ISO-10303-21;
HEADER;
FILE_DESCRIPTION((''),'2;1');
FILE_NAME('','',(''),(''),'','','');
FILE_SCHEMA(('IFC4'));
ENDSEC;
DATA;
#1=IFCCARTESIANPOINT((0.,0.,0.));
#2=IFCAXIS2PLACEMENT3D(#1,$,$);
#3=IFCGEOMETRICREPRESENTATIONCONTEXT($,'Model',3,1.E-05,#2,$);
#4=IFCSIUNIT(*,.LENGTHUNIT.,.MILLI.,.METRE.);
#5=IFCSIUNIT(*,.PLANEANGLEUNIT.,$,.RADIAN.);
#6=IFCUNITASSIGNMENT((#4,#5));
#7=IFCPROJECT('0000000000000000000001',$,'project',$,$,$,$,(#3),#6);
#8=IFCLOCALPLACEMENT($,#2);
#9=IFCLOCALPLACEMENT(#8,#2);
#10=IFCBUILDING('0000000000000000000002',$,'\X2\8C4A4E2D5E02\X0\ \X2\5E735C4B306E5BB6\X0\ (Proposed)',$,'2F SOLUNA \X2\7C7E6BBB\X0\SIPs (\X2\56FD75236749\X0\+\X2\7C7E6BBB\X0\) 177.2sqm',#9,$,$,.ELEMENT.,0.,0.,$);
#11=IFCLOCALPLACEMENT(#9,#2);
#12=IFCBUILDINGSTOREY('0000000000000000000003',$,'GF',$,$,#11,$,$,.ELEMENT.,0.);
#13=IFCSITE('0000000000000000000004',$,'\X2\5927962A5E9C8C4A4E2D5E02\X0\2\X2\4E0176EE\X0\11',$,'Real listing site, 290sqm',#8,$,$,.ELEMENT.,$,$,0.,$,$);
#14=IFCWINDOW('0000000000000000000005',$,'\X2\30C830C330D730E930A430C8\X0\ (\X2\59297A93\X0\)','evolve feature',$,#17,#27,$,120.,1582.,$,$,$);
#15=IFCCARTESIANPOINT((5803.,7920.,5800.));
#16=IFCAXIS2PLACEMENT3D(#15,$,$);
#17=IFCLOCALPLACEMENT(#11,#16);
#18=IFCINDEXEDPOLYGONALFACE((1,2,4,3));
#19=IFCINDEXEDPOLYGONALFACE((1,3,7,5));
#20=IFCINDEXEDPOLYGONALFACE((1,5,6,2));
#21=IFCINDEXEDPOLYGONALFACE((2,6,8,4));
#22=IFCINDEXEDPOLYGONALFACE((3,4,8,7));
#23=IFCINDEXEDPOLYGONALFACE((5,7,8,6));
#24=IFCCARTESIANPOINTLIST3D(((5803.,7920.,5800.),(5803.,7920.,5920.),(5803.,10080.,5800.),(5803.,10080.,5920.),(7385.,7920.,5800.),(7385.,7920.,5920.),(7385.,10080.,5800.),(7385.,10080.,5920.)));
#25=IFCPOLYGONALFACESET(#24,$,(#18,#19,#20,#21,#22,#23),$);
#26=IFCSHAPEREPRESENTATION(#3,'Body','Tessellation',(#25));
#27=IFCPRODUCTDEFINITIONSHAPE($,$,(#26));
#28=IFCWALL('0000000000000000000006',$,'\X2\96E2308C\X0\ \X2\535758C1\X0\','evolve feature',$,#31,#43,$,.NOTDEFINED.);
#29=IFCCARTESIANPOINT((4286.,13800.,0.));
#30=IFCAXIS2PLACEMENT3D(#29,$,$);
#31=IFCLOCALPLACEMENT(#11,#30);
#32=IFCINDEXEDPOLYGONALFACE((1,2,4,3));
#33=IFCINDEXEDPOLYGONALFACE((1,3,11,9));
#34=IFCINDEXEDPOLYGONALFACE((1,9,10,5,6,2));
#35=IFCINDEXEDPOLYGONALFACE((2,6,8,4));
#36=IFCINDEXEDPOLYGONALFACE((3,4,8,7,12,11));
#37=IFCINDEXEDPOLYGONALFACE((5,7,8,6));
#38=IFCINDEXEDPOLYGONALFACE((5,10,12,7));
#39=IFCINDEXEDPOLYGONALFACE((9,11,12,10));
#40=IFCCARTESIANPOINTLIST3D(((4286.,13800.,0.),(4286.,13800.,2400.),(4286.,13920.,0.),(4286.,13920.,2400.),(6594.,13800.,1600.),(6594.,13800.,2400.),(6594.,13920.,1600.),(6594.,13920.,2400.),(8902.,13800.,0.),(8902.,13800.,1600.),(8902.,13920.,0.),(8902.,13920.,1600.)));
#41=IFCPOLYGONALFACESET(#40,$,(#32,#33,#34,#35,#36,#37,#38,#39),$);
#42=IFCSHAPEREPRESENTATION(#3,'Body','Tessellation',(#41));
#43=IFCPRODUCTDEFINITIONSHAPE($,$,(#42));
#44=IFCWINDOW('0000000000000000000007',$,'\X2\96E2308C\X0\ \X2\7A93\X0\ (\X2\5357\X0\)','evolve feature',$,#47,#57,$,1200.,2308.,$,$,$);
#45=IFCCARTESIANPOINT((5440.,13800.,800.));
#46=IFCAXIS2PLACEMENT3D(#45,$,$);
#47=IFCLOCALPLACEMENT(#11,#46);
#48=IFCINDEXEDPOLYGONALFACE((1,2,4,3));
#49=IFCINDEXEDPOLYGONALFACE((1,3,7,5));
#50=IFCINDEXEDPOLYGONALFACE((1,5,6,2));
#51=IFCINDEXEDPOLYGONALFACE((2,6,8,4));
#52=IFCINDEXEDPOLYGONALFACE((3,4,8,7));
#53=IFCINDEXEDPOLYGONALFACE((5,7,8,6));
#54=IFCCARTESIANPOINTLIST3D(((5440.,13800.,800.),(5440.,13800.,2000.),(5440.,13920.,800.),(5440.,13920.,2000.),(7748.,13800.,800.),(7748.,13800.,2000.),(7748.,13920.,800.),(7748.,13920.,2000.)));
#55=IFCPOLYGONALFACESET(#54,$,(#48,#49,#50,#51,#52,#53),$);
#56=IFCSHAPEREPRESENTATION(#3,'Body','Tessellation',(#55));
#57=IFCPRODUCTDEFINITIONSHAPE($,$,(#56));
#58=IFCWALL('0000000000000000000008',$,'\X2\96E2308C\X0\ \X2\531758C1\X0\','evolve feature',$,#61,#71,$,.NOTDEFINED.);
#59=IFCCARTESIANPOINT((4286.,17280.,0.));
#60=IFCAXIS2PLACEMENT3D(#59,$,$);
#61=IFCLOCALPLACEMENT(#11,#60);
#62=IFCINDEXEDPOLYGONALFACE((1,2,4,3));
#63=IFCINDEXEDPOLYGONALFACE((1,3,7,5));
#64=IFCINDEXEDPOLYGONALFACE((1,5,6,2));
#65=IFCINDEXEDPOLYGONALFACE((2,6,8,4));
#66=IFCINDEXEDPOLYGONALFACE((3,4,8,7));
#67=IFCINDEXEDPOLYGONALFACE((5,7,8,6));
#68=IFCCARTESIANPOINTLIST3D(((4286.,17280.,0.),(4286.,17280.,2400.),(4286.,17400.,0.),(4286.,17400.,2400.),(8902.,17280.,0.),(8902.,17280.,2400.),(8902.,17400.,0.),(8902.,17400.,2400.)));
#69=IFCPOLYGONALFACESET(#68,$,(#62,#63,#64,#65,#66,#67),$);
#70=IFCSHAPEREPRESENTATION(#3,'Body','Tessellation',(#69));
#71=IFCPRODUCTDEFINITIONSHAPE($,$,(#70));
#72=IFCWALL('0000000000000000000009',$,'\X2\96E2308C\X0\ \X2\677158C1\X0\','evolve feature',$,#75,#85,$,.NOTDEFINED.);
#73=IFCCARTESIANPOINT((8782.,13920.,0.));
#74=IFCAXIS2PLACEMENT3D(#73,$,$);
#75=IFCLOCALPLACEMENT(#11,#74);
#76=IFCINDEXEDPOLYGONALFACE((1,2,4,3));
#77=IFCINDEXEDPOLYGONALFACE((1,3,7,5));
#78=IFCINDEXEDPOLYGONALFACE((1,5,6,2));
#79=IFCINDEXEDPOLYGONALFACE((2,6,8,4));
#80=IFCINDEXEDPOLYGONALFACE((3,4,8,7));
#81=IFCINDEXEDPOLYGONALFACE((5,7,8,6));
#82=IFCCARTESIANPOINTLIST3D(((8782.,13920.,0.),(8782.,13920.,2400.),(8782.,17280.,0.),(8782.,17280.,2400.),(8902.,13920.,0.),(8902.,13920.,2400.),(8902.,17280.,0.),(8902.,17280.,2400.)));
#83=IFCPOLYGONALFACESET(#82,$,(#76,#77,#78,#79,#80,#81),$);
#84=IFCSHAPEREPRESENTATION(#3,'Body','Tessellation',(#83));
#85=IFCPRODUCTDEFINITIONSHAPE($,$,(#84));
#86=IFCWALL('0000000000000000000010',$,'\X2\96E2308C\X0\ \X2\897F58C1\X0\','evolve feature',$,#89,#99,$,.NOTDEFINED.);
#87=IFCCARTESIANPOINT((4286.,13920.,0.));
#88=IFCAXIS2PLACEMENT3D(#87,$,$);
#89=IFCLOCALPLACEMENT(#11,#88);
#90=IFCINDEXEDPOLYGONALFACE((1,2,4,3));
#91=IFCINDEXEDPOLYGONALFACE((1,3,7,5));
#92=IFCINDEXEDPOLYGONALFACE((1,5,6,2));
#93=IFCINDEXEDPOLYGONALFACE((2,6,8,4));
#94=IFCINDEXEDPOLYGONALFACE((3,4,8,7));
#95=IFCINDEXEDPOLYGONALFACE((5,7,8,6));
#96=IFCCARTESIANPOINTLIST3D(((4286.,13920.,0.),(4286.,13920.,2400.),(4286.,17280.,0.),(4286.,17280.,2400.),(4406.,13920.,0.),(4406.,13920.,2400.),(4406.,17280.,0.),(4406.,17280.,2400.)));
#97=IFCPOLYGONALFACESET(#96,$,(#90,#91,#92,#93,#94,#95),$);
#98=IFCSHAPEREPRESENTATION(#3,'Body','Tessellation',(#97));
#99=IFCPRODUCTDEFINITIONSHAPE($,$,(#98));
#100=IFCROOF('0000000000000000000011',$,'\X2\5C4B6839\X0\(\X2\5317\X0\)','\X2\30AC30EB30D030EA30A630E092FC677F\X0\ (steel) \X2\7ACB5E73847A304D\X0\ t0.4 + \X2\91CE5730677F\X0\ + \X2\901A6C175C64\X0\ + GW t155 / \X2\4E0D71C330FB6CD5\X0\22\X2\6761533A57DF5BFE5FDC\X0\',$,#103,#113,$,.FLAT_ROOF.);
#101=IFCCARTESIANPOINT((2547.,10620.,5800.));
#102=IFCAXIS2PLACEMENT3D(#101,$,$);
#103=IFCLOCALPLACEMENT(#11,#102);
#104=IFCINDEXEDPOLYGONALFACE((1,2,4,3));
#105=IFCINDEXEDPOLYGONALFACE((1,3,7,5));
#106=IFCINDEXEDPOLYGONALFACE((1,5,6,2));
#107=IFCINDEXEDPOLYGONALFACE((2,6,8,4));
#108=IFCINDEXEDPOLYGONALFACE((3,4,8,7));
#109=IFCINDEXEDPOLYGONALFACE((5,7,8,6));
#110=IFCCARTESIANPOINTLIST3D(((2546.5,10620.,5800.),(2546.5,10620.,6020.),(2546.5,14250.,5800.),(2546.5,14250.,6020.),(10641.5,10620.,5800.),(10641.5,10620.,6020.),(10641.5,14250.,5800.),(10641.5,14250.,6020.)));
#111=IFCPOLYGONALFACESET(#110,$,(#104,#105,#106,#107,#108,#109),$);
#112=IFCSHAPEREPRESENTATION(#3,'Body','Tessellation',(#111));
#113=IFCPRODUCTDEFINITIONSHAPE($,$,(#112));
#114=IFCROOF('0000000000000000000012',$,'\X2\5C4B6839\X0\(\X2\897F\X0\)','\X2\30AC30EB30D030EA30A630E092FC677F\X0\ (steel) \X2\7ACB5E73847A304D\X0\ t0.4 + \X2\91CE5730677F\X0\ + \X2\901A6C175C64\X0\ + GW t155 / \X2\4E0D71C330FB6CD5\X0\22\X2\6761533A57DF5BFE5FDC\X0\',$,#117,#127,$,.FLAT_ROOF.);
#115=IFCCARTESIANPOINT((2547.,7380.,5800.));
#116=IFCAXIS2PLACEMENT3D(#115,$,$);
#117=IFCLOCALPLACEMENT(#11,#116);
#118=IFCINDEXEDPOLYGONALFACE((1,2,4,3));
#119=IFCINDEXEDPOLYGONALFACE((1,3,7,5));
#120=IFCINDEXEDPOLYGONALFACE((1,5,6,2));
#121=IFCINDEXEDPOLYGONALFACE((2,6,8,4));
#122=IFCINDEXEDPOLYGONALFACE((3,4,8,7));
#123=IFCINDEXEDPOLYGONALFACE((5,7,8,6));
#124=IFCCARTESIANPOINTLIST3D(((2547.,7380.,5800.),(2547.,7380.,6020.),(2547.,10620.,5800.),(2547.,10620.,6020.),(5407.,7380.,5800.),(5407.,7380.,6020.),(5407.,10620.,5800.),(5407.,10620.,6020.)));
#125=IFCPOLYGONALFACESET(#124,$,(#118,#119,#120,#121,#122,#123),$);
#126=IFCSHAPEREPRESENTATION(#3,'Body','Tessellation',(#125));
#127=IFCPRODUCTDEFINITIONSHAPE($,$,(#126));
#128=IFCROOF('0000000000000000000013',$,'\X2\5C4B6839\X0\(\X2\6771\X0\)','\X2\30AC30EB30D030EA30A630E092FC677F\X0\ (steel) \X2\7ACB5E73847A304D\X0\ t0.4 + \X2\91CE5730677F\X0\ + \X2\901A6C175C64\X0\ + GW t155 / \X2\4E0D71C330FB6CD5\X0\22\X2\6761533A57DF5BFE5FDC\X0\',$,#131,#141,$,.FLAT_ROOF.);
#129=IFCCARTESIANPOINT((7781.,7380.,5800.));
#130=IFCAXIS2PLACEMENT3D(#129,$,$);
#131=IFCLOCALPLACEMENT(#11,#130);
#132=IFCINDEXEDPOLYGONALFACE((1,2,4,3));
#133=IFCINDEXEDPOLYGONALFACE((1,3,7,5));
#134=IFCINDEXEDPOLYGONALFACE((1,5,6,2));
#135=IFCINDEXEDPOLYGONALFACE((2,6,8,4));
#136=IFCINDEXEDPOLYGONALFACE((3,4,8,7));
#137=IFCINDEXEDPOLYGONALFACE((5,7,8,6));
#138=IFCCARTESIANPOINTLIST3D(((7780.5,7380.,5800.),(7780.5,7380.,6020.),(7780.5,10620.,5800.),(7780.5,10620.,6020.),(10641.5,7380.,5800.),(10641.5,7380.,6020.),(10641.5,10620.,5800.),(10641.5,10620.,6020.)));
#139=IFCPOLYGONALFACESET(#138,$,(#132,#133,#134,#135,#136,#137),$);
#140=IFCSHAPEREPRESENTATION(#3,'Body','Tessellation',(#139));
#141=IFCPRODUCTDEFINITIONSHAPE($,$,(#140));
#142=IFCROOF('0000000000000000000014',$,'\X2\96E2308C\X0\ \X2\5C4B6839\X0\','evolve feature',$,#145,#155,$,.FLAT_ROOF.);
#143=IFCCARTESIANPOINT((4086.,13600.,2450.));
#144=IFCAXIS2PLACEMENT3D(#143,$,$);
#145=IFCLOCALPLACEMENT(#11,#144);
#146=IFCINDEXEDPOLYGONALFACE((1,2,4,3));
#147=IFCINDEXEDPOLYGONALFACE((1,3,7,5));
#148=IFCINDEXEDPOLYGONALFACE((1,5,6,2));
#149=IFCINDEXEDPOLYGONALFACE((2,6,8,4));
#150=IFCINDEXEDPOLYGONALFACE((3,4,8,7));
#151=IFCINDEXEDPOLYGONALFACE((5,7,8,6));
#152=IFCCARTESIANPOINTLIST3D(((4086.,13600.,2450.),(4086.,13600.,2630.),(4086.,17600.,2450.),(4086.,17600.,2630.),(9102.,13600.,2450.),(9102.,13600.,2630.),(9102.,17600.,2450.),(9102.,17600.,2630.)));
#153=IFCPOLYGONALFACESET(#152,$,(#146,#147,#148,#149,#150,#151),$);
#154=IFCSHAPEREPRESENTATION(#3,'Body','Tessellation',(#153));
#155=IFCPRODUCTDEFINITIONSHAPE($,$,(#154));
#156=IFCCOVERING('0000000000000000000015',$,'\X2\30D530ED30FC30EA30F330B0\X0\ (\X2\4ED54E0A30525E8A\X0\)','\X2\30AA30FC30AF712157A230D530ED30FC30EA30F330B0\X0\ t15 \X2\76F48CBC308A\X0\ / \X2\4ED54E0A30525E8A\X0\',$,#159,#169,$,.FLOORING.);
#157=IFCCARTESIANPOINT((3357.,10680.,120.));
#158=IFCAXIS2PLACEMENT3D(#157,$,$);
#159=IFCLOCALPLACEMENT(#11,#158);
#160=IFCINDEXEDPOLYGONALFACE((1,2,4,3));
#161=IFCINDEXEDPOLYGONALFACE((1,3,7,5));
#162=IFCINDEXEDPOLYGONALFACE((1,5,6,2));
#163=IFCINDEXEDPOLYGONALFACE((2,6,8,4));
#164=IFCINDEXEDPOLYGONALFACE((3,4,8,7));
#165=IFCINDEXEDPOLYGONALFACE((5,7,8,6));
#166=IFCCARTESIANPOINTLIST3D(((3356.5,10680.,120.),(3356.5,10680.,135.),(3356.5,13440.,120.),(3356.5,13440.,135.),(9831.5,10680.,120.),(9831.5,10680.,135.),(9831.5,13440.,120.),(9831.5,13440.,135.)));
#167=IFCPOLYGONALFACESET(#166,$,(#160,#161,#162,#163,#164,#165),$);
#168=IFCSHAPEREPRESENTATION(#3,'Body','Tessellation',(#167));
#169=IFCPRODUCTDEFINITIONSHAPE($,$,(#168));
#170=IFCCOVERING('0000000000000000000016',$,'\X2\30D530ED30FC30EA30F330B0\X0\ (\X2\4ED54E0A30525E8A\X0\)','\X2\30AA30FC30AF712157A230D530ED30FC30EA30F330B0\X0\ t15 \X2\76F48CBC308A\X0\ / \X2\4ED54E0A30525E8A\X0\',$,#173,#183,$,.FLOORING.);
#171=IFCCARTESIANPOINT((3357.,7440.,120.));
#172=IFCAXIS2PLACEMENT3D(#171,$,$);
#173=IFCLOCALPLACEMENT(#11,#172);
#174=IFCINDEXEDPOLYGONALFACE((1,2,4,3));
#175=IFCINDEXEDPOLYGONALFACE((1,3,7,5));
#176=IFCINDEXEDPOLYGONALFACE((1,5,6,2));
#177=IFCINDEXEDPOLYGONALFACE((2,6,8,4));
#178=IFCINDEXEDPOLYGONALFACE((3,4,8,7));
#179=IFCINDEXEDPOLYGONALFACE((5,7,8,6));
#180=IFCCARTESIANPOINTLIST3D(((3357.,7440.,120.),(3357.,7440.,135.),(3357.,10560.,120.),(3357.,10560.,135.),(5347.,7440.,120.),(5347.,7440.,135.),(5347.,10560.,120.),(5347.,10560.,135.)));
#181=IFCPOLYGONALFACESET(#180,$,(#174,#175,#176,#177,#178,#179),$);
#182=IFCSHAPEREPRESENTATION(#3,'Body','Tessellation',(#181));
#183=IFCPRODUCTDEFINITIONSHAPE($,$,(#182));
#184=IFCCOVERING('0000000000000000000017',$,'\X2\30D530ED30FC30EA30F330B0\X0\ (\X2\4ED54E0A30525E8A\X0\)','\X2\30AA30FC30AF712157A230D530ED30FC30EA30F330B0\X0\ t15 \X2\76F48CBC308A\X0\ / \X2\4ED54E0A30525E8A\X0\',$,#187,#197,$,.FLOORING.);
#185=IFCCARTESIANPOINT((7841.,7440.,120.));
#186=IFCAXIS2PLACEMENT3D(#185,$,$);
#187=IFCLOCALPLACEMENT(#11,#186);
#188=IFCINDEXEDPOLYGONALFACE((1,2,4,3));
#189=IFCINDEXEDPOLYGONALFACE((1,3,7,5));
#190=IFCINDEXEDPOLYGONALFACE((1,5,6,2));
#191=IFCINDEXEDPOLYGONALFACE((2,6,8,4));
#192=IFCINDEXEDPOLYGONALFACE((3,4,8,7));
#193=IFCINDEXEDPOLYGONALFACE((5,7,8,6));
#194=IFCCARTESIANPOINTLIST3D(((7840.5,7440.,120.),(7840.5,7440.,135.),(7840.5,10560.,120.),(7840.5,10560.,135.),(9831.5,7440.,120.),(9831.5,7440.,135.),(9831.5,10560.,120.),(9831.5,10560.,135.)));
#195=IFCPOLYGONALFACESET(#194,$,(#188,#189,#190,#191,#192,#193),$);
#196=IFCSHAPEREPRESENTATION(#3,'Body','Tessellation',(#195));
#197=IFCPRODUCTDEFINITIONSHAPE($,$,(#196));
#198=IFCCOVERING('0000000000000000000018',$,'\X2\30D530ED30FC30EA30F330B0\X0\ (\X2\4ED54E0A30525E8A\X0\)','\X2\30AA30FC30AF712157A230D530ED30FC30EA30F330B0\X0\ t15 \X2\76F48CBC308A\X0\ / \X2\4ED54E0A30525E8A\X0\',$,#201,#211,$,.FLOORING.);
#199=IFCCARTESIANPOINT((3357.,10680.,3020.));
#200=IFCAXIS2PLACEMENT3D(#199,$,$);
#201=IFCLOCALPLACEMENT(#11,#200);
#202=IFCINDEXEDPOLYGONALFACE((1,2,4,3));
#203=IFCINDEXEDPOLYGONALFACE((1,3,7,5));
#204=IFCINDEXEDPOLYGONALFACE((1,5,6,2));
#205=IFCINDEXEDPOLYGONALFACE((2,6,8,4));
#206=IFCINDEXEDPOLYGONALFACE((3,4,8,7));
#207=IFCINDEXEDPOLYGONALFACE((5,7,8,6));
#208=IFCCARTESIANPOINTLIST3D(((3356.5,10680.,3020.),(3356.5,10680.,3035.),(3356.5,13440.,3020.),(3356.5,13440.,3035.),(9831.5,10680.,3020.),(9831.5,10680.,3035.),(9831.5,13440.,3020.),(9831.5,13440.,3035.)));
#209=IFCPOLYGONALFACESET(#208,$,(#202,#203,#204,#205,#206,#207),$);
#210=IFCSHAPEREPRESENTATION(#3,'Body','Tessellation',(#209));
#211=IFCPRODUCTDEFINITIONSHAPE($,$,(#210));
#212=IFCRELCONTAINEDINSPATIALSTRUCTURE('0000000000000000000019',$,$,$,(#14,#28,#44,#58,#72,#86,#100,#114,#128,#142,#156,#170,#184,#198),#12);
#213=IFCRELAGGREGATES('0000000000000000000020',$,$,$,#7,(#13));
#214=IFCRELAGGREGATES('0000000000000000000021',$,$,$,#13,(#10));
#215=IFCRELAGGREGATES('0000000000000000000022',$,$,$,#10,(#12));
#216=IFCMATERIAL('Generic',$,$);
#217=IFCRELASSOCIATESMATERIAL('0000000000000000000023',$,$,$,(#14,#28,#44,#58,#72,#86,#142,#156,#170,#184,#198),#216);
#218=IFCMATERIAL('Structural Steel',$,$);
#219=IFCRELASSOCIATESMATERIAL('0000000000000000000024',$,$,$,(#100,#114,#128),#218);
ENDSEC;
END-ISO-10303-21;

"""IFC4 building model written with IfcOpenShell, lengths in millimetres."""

from ifc_helpers import new_model, si_unit, frame, frame_2d, origin, place, context, project, spatial, rectangle, extrude, material, element, fill, save


model = new_model("IFC4")

# Units and contexts
model_context = context("Model", 3, precision=1e-05, world=origin())
ifc_project = project(units=[si_unit("LENGTHUNIT", "METRE", prefix="MILLI"), si_unit("PLANEANGLEUNIT", "RADIAN")], contexts=[model_context])

# Site, building, storey
site_placement = place(None, origin())
site = spatial("IfcSite", under=ifc_project, at=site_placement, Name="大阪府豊中市2丁目11", ObjectType="Real listing site, 290sqm", CompositionType="ELEMENT", RefElevation=0.0)
building_placement = place(site_placement, origin())
building = spatial("IfcBuilding", under=site, at=building_placement, Name="豊中市 平屋の家 (Proposed)", ObjectType="2F SOLUNA 籾殻SIPs (国産杉+籾殻) 177.2sqm", CompositionType="ELEMENT", ElevationOfRefHeight=0.0, ElevationOfTerrain=0.0)
storey_placement = place(building_placement, origin())
storey = spatial("IfcBuildingStorey", under=building, at=storey_placement, Name="GF", CompositionType="ELEMENT", Elevation=0.0)

# Shared definitions
ifc_material_1 = material(Name="Generic")

# Window
window_1_placement = place(storey_placement, frame((5803.0, 7920.0, 5800.0)))
element("IfcWindow", 1, at=window_1_placement, inside=storey, material=ifc_material_1, Name="トップライト (天窓)", Description="evolve feature", OverallHeight=120.0, OverallWidth=1582.0, context=model_context, shape_type="SweptSolid", body=[
    extrude(rectangle(XDim=1582.0, YDim=2160.0, at=frame_2d((791.0, 1080.0))), frame((5803.0, 7920.0, 5800.0)), (0.0, 0.0, 1.0), 120.0),
])

# Wall, opening, window
wall_1_placement = place(storey_placement, frame((4286.0, 13800.0, 0.0)))
wall_1 = element("IfcWall", 2, at=wall_1_placement, inside=storey, material=ifc_material_1, Name="離れ 南壁", Description="evolve feature", PredefinedType="NOTDEFINED", context=model_context, shape_type="SweptSolid", body=[
    extrude(rectangle(XDim=4616.0, YDim=120.0, at=frame_2d((2308.0, 60.0))), frame((4286.0, 13800.0, 0.0)), (0.0, 0.0, 1.0), 2400.0),
])
opening_1_placement = place(storey_placement, frame((5440.0, 13800.0, 800.0)))
opening_1 = element("IfcOpeningElement", 3, at=opening_1_placement, cuts=wall_1, PredefinedType="NOTDEFINED", context=model_context, shape_type="SweptSolid", body=[
    extrude(rectangle(XDim=2308.0, YDim=120.0, at=frame_2d((1154.0, 60.0))), frame((5440.0, 13800.0, 800.0)), (0.0, 0.0, 1.0), 1200.0),
])
window_2_placement = place(storey_placement, frame((5440.0, 13800.0, 800.0)))
window_2 = element("IfcWindow", 4, at=window_2_placement, inside=storey, material=ifc_material_1, Name="離れ 窓 (南)", Description="evolve feature", OverallHeight=1200.0, OverallWidth=2308.0, context=model_context, shape_type="SweptSolid", body=[
    extrude(rectangle(XDim=2308.0, YDim=120.0, at=frame_2d((1154.0, 60.0))), frame((5440.0, 13800.0, 800.0)), (0.0, 0.0, 1.0), 1200.0),
])
fill(opening_1, window_2)

# Walls
wall_2_placement = place(storey_placement, frame((4286.0, 17280.0, 0.0)))
element("IfcWall", 5, at=wall_2_placement, inside=storey, material=ifc_material_1, Name="離れ 北壁", Description="evolve feature", PredefinedType="NOTDEFINED", context=model_context, shape_type="SweptSolid", body=[
    extrude(rectangle(XDim=4616.0, YDim=120.0, at=frame_2d((2308.0, 60.0))), frame((4286.0, 17280.0, 0.0)), (0.0, 0.0, 1.0), 2400.0),
])
wall_3_placement = place(storey_placement, frame((8782.0, 13920.0, 0.0)))
element("IfcWall", 6, at=wall_3_placement, inside=storey, material=ifc_material_1, Name="離れ 東壁", Description="evolve feature", PredefinedType="NOTDEFINED", context=model_context, shape_type="SweptSolid", body=[
    extrude(rectangle(XDim=120.0, YDim=3360.0, at=frame_2d((60.0, 1680.0))), frame((8782.0, 13920.0, 0.0)), (0.0, 0.0, 1.0), 2400.0),
])
wall_4_placement = place(storey_placement, frame((4286.0, 13920.0, 0.0)))
element("IfcWall", 7, at=wall_4_placement, inside=storey, material=ifc_material_1, Name="離れ 西壁", Description="evolve feature", PredefinedType="NOTDEFINED", context=model_context, shape_type="SweptSolid", body=[
    extrude(rectangle(XDim=120.0, YDim=3360.0, at=frame_2d((60.0, 1680.0))), frame((4286.0, 13920.0, 0.0)), (0.0, 0.0, 1.0), 2400.0),
])

# Roofs
ifc_material_2 = material(Name="Structural Steel")
for number, where, name in (
    (8, (2547.0, 10620.0, 5800.0), "屋根(北)"),
):
    element("IfcRoof", number, at=place(storey_placement, frame(where)), inside=storey, material=ifc_material_2, Name=name, Description="ガルバリウム鋼板 (steel) 立平葺き t0.4 + 野地板 + 通気層 + GW t155 / 不燃・法22条区域対応", PredefinedType="FLAT_ROOF", context=model_context, shape_type="SweptSolid", body=[
        extrude(rectangle(XDim=8095.0, YDim=3630.0, at=frame_2d((4047.0, 1815.0))), frame((2547.0, 10620.0, 5800.0)), (0.0, 0.0, 1.0), 220.0),
    ])
roof_1_placement = place(storey_placement, frame((2547.0, 7380.0, 5800.0)))
element("IfcRoof", 9, at=roof_1_placement, inside=storey, material=ifc_material_2, Name="屋根(西)", Description="ガルバリウム鋼板 (steel) 立平葺き t0.4 + 野地板 + 通気層 + GW t155 / 不燃・法22条区域対応", PredefinedType="FLAT_ROOF", context=model_context, shape_type="SweptSolid", body=[
    extrude(rectangle(XDim=2860.0, YDim=3240.0, at=frame_2d((1430.0, 1620.0))), frame((2547.0, 7380.0, 5800.0)), (0.0, 0.0, 1.0), 220.0),
])
roof_2_placement = place(storey_placement, frame((7781.0, 7380.0, 5800.0)))
element("IfcRoof", 10, at=roof_2_placement, inside=storey, material=ifc_material_2, Name="屋根(東)", Description="ガルバリウム鋼板 (steel) 立平葺き t0.4 + 野地板 + 通気層 + GW t155 / 不燃・法22条区域対応", PredefinedType="FLAT_ROOF", context=model_context, shape_type="SweptSolid", body=[
    extrude(rectangle(XDim=2861.0, YDim=3240.0, at=frame_2d((1430.0, 1620.0))), frame((7781.0, 7380.0, 5800.0)), (0.0, 0.0, 1.0), 220.0),
])
roof_3_placement = place(storey_placement, frame((4086.0, 13600.0, 2450.0)))
element("IfcRoof", 11, at=roof_3_placement, inside=storey, material=ifc_material_1, Name="離れ 屋根", Description="evolve feature", PredefinedType="FLAT_ROOF", context=model_context, shape_type="SweptSolid", body=[
    extrude(rectangle(XDim=5016.0, YDim=4000.0, at=frame_2d((2508.0, 2000.0))), frame((4086.0, 13600.0, 2450.0)), (0.0, 0.0, 1.0), 180.0),
])

# Coverings
covering_1_placement = place(storey_placement, frame((3357.0, 10680.0, 120.0)))
element("IfcCovering", 12, at=covering_1_placement, inside=storey, material=ifc_material_1, Name="フローリング (仕上げ床)", Description="オーク無垢フローリング t15 直貼り / 仕上げ床", PredefinedType="FLOORING", context=model_context, shape_type="SweptSolid", body=[
    extrude(rectangle(XDim=6475.0, YDim=2760.0, at=frame_2d((3237.0, 1380.0))), frame((3357.0, 10680.0, 120.0)), (0.0, 0.0, 1.0), 15.0),
])
covering_2_placement = place(storey_placement, frame((3357.0, 7440.0, 120.0)))
element("IfcCovering", 13, at=covering_2_placement, inside=storey, material=ifc_material_1, Name="フローリング (仕上げ床)", Description="オーク無垢フローリング t15 直貼り / 仕上げ床", PredefinedType="FLOORING", context=model_context, shape_type="SweptSolid", body=[
    extrude(rectangle(XDim=1990.0, YDim=3120.0, at=frame_2d((995.0, 1560.0))), frame((3357.0, 7440.0, 120.0)), (0.0, 0.0, 1.0), 15.0),
])
covering_3_placement = place(storey_placement, frame((7841.0, 7440.0, 120.0)))
element("IfcCovering", 14, at=covering_3_placement, inside=storey, material=ifc_material_1, Name="フローリング (仕上げ床)", Description="オーク無垢フローリング t15 直貼り / 仕上げ床", PredefinedType="FLOORING", context=model_context, shape_type="SweptSolid", body=[
    extrude(rectangle(XDim=1991.0, YDim=3120.0, at=frame_2d((995.0, 1560.0))), frame((7841.0, 7440.0, 120.0)), (0.0, 0.0, 1.0), 15.0),
])
covering_4_placement = place(storey_placement, frame((3357.0, 10680.0, 3020.0)))
element("IfcCovering", 15, at=covering_4_placement, inside=storey, material=ifc_material_1, Name="フローリング (仕上げ床)", Description="オーク無垢フローリング t15 直貼り / 仕上げ床", PredefinedType="FLOORING", context=model_context, shape_type="SweptSolid", body=[
    extrude(rectangle(XDim=6475.0, YDim=2760.0, at=frame_2d((3237.0, 1380.0))), frame((3357.0, 10680.0, 3020.0)), (0.0, 0.0, 1.0), 15.0),
])

save(model, "model.ifc")
